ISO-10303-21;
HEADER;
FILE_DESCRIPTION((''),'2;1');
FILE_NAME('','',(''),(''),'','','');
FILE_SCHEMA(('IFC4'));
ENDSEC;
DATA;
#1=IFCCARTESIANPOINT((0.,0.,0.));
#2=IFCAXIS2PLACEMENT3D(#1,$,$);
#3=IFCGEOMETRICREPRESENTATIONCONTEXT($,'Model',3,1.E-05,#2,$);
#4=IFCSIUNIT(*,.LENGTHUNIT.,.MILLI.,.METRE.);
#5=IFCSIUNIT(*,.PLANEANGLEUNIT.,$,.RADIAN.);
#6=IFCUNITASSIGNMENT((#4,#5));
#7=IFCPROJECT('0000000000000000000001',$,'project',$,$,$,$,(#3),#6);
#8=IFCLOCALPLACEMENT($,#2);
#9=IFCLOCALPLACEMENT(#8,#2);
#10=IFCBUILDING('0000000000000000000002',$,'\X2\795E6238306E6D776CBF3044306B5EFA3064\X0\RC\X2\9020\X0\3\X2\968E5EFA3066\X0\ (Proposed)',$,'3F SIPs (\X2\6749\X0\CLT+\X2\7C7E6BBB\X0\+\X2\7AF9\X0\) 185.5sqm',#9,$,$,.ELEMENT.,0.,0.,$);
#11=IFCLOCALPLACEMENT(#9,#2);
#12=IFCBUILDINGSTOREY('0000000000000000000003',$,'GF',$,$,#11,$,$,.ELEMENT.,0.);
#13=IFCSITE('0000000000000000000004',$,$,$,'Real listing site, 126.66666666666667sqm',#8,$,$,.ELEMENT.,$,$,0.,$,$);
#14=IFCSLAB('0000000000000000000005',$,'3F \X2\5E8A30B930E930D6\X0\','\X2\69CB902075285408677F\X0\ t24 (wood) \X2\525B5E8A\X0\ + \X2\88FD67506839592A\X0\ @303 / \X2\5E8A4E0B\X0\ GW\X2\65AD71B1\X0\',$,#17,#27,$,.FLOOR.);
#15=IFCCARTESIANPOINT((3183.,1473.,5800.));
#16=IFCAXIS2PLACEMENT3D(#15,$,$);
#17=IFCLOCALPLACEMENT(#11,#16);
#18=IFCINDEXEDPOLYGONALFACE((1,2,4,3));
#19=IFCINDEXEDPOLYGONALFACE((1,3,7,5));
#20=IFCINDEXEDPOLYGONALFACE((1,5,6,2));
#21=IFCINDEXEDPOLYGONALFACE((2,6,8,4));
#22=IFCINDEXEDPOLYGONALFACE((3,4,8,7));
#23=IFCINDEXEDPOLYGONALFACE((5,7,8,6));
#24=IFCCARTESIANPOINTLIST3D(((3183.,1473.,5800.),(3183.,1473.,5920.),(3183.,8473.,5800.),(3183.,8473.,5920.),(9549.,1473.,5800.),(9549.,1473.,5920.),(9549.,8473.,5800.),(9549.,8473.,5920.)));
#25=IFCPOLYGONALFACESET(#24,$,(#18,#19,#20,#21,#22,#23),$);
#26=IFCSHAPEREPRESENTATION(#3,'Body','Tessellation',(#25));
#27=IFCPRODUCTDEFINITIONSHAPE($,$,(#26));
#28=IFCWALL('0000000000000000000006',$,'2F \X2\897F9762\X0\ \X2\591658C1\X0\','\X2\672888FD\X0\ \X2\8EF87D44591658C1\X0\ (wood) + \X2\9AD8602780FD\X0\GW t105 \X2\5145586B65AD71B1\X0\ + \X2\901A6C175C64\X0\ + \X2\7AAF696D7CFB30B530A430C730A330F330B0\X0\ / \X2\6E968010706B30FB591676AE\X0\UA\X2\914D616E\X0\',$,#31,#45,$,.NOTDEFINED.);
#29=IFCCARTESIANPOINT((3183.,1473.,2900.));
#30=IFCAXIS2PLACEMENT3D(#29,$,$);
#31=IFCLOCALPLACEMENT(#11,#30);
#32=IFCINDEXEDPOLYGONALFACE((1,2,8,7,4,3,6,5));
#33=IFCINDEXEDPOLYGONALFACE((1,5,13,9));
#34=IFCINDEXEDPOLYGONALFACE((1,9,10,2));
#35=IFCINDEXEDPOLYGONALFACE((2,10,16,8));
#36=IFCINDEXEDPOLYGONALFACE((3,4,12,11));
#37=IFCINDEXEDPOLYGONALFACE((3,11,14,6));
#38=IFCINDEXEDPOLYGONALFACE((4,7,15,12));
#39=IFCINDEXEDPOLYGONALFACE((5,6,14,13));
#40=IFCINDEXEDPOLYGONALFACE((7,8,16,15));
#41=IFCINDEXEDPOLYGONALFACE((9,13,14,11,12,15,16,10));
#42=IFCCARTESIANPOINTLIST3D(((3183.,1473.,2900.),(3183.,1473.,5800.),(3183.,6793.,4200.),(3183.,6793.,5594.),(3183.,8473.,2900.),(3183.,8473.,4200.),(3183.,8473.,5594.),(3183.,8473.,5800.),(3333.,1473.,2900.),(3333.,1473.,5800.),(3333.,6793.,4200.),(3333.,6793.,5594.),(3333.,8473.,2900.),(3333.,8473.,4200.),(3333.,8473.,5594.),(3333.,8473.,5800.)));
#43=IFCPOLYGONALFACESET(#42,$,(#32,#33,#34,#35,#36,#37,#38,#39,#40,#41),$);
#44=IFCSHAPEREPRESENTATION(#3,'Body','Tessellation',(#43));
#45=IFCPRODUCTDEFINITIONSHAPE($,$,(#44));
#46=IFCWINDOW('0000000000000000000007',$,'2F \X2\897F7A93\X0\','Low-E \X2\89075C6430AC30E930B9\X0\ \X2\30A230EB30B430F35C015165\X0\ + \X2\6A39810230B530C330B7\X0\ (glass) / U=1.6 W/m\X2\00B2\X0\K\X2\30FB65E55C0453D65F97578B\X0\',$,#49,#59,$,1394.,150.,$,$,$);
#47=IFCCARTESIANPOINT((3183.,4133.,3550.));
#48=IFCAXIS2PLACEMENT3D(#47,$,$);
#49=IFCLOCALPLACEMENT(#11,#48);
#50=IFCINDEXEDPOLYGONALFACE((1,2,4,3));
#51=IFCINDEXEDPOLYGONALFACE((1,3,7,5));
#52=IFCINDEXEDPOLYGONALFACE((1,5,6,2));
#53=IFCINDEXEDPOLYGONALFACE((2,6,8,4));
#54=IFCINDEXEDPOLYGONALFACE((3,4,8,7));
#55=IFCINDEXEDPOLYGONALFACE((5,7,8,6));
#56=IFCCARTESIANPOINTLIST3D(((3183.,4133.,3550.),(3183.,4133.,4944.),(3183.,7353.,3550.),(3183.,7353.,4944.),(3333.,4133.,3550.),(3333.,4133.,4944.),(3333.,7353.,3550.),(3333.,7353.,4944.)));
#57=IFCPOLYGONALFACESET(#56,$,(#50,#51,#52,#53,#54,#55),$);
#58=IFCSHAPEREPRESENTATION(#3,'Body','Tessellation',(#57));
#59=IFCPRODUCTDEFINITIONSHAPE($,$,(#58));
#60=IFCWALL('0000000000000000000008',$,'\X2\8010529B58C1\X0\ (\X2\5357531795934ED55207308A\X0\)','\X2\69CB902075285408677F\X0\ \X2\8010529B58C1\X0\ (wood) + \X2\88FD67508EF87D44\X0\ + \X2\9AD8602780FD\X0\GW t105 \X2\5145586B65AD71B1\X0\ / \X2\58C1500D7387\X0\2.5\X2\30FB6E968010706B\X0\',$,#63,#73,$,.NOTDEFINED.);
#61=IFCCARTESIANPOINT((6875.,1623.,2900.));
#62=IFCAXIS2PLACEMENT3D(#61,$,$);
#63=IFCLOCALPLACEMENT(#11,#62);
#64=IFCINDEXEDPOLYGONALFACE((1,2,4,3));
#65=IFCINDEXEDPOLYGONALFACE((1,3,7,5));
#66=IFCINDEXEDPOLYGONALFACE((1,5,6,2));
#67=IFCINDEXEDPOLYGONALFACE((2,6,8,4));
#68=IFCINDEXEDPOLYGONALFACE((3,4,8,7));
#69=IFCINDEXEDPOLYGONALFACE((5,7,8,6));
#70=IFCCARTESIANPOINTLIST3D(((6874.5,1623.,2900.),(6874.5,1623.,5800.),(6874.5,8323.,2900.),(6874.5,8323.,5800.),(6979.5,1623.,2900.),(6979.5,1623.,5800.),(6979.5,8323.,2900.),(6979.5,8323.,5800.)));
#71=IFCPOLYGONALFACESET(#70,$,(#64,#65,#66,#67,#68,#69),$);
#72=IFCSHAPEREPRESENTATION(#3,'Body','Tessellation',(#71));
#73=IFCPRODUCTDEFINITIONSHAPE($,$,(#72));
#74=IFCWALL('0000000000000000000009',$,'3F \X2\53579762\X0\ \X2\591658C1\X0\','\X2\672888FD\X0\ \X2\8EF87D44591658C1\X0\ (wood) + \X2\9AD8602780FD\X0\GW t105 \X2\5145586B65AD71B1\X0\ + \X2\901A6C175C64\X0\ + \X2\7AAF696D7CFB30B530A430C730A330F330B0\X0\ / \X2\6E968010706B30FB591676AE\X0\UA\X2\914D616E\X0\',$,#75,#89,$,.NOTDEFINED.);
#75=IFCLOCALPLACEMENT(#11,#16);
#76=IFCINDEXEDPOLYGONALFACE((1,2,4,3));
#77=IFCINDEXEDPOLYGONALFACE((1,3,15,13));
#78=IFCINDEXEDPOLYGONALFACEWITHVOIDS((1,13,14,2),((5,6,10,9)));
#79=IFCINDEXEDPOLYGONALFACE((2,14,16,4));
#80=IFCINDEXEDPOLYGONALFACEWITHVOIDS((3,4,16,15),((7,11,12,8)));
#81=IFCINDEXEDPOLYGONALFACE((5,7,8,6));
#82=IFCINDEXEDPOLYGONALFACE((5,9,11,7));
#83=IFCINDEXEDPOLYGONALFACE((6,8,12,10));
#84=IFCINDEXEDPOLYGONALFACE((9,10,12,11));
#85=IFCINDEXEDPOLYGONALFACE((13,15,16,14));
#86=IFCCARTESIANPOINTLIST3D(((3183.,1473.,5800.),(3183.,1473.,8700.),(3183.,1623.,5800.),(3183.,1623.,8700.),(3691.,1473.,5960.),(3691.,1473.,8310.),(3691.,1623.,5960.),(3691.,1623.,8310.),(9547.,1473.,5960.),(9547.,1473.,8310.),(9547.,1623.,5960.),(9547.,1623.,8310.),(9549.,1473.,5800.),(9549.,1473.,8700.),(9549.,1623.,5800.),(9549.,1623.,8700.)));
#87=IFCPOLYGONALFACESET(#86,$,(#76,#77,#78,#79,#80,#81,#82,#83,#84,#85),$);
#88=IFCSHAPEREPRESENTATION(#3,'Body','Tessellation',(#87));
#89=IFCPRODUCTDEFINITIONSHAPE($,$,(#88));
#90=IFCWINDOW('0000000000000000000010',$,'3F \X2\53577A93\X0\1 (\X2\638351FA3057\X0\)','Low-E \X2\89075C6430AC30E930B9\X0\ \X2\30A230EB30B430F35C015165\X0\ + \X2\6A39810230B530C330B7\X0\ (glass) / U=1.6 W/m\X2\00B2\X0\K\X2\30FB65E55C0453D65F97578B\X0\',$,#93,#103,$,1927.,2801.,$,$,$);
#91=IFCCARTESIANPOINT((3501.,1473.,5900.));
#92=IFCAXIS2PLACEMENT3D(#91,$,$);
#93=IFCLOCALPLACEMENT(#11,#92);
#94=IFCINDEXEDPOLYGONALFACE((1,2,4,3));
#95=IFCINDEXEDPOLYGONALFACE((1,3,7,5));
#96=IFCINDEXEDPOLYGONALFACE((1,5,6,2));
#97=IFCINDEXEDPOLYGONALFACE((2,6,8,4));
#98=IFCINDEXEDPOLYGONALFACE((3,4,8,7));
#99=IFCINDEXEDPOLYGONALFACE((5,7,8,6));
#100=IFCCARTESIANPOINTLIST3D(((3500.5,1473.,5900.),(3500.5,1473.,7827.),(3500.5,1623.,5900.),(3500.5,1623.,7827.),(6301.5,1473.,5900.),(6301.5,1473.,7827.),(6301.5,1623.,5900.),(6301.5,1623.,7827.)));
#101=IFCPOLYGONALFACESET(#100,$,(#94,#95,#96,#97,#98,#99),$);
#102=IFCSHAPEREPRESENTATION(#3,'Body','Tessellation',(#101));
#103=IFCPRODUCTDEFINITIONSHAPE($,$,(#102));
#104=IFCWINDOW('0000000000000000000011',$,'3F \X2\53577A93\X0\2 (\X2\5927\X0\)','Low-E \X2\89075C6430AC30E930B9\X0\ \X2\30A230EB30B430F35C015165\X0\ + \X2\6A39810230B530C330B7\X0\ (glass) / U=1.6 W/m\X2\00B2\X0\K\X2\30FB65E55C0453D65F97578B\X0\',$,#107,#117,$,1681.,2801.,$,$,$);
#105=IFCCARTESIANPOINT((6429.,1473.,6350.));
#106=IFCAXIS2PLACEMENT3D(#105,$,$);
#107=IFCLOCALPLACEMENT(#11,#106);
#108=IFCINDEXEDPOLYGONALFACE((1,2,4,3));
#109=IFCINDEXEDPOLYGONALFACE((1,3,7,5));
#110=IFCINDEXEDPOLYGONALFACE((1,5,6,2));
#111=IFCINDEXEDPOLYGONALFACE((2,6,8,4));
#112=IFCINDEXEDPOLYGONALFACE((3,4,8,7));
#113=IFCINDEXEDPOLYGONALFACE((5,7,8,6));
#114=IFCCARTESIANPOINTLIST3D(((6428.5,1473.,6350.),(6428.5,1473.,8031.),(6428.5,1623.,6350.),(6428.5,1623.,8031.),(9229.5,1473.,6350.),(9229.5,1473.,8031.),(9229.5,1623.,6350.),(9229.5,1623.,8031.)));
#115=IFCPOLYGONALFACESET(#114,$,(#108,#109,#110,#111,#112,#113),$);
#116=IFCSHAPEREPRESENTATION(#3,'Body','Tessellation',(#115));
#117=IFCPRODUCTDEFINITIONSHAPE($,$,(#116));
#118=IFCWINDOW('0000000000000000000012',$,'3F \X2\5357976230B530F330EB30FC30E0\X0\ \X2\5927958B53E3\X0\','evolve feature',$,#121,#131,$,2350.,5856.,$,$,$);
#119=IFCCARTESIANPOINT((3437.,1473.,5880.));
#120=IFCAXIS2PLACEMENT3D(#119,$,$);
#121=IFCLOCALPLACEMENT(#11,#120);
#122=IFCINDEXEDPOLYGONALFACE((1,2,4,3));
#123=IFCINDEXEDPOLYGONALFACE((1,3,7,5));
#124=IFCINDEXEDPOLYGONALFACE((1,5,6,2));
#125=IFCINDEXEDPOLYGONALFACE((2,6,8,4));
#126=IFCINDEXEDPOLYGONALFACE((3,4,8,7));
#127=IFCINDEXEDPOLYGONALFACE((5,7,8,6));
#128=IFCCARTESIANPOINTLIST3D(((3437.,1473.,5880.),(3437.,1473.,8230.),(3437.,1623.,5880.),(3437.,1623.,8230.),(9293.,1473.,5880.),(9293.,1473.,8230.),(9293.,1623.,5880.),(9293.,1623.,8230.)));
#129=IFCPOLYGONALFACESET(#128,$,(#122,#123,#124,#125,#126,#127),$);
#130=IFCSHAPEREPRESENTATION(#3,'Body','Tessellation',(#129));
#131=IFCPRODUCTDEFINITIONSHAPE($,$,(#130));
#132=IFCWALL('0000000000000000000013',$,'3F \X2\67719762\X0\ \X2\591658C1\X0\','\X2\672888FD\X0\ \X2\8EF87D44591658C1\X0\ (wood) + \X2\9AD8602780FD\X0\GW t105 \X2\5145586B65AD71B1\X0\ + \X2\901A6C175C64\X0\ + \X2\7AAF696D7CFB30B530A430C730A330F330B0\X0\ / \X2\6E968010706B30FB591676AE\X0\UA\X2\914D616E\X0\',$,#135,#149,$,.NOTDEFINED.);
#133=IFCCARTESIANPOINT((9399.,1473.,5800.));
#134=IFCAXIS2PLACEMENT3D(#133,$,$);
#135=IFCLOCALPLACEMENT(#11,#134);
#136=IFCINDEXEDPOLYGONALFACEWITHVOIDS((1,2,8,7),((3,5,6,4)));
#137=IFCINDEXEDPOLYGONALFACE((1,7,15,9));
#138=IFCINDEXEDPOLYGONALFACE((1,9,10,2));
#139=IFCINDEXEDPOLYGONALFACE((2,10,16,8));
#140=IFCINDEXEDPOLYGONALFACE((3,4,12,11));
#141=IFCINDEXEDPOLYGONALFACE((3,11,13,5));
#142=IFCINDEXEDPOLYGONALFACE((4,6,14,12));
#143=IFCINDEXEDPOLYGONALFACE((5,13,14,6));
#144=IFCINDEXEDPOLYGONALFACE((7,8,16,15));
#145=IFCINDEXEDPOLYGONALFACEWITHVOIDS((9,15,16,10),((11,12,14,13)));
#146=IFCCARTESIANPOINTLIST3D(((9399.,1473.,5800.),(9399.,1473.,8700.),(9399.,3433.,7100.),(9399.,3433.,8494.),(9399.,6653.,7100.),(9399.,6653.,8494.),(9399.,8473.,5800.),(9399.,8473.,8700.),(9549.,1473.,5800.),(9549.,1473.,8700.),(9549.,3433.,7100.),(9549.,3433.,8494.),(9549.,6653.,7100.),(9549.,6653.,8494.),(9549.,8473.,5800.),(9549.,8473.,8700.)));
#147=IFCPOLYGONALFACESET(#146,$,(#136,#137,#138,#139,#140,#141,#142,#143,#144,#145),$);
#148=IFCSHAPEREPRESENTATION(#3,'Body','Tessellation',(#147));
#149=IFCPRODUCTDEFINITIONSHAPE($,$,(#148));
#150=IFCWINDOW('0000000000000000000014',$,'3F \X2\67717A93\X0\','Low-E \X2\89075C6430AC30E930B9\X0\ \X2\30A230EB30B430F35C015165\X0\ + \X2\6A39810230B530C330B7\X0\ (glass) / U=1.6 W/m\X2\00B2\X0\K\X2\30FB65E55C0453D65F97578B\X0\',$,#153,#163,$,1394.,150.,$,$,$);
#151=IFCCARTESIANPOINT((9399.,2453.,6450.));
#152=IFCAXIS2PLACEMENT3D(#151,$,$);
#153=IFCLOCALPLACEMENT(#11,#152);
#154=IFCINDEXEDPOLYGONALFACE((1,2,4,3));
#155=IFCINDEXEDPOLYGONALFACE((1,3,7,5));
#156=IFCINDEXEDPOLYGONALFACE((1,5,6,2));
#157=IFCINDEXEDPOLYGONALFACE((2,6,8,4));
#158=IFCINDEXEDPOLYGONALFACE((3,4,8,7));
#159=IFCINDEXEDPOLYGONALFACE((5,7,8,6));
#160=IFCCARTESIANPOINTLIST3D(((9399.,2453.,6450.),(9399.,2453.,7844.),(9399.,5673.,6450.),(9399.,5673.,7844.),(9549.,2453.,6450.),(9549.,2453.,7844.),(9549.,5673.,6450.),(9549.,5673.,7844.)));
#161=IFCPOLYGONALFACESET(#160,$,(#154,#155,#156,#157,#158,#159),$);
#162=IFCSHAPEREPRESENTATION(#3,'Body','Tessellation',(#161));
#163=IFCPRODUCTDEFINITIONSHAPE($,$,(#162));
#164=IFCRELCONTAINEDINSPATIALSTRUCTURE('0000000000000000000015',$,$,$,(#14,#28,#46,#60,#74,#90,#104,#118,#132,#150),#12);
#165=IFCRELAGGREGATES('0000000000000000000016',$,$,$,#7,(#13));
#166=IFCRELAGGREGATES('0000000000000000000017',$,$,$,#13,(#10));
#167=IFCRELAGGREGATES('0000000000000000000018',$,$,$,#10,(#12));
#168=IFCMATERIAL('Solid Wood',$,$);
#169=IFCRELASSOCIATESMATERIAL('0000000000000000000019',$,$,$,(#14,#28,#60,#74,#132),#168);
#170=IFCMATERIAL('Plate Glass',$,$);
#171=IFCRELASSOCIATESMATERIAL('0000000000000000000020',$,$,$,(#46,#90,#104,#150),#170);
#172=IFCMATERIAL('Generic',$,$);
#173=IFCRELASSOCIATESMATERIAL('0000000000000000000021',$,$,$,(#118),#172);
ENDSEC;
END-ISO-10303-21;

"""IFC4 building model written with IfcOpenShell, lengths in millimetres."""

from ifc_helpers import new_model, si_unit, frame, frame_2d, origin, place, context, project, spatial, rectangle, extrude, material, element, fill, save


model = new_model("IFC4")

# Units and contexts
model_context = context("Model", 3, precision=1e-05, world=origin())
ifc_project = project(units=[si_unit("LENGTHUNIT", "METRE", prefix="MILLI"), si_unit("PLANEANGLEUNIT", "RADIAN")], contexts=[model_context])

# Site, building, storey
site_placement = place(None, origin())
site = spatial("IfcSite", under=ifc_project, at=site_placement, ObjectType="Real listing site, 126.66666666666667sqm", CompositionType="ELEMENT", RefElevation=0.0)
building_placement = place(site_placement, origin())
building = spatial("IfcBuilding", under=site, at=building_placement, Name="神戸の海沿いに建つRC造3階建て (Proposed)", ObjectType="3F SIPs (杉CLT+籾殻+竹) 185.5sqm", CompositionType="ELEMENT", ElevationOfRefHeight=0.0, ElevationOfTerrain=0.0)
storey_placement = place(building_placement, origin())
storey = spatial("IfcBuildingStorey", under=building, at=storey_placement, Name="GF", CompositionType="ELEMENT", Elevation=0.0)

# Slab
ifc_material_1 = material(Name="Solid Wood")
slab_placement = place(storey_placement, frame((3183.0, 1473.0, 5800.0)))
element("IfcSlab", 1, at=slab_placement, inside=storey, material=ifc_material_1, Name="3F 床スラブ", Description="構造用合板 t24 (wood) 剛床 + 製材根太 @303 / 床下 GW断熱", PredefinedType="FLOOR", context=model_context, shape_type="SweptSolid", body=[
    extrude(rectangle(XDim=6366.0, YDim=7000.0, at=frame_2d((3183.0, 3500.0))), frame((3183.0, 1473.0, 5800.0)), (0.0, 0.0, 1.0), 120.0),
])

# Wall, opening, window
wall_1_placement = place(storey_placement, frame((3183.0, 1473.0, 2900.0)))
wall_1 = element("IfcWall", 2, at=wall_1_placement, inside=storey, material=ifc_material_1, Name="2F 西面 外壁", Description="木製 軸組外壁 (wood) + 高性能GW t105 充填断熱 + 通気層 + 窯業系サイディング / 準耐火・外皮UA配慮", PredefinedType="NOTDEFINED", context=model_context, shape_type="SweptSolid", body=[
    extrude(rectangle(XDim=150.0, YDim=7000.0, at=frame_2d((75.0, 3500.0))), frame((3183.0, 1473.0, 2900.0)), (0.0, 0.0, 1.0), 2900.0),
])
opening_1_placement = place(storey_placement, frame((3183.0, 4133.0, 3550.0)))
opening_1 = element("IfcOpeningElement", 3, at=opening_1_placement, cuts=wall_1, PredefinedType="NOTDEFINED", context=model_context, shape_type="SweptSolid", body=[
    extrude(rectangle(XDim=150.0, YDim=3220.0, at=frame_2d((75.0, 1610.0))), frame((3183.0, 4133.0, 3550.0)), (0.0, 0.0, 1.0), 1394.0),
])
ifc_material_2 = material(Name="Plate Glass")
window_1_placement = place(storey_placement, frame((3183.0, 4133.0, 3550.0)))
window_1 = element("IfcWindow", 4, at=window_1_placement, inside=storey, material=ifc_material_2, Name="2F 西窓", Description="Low-E 複層ガラス アルゴン封入 + 樹脂サッシ (glass) / U=1.6 W/m²K・日射取得型", OverallHeight=1394.0, OverallWidth=150.0, context=model_context, shape_type="SweptSolid", body=[
    extrude(rectangle(XDim=150.0, YDim=3220.0, at=frame_2d((75.0, 1610.0))), frame((3183.0, 4133.0, 3550.0)), (0.0, 0.0, 1.0), 1394.0),
])
fill(opening_1, window_1)

# Wall
wall_2_placement = place(storey_placement, frame((6875.0, 1623.0, 2900.0)))
element("IfcWall", 5, at=wall_2_placement, inside=storey, material=ifc_material_1, Name="耐力壁 (南北間仕切り)", Description="構造用合板 耐力壁 (wood) + 製材軸組 + 高性能GW t105 充填断熱 / 壁倍率2.5・準耐火", PredefinedType="NOTDEFINED", context=model_context, shape_type="SweptSolid", body=[
    extrude(rectangle(XDim=105.0, YDim=6700.0, at=frame_2d((52.0, 3350.0))), frame((6875.0, 1623.0, 2900.0)), (0.0, 0.0, 1.0), 2900.0),
])

# Wall, openings, windows
wall_3_placement = place(storey_placement, frame((3183.0, 1473.0, 5800.0)))
wall_3 = element("IfcWall", 6, at=wall_3_placement, inside=storey, material=ifc_material_1, Name="3F 南面 外壁", Description="木製 軸組外壁 (wood) + 高性能GW t105 充填断熱 + 通気層 + 窯業系サイディング / 準耐火・外皮UA配慮", PredefinedType="NOTDEFINED", context=model_context, shape_type="SweptSolid", body=[
    extrude(rectangle(XDim=6366.0, YDim=150.0, at=frame_2d((3183.0, 75.0))), frame((3183.0, 1473.0, 5800.0)), (0.0, 0.0, 1.0), 2900.0),
])
opening_2_placement = place(storey_placement, frame((3501.0, 1473.0, 5900.0)))
opening_2 = element("IfcOpeningElement", 7, at=opening_2_placement, cuts=wall_3, PredefinedType="NOTDEFINED", context=model_context, shape_type="SweptSolid", body=[
    extrude(rectangle(XDim=2801.0, YDim=150.0, at=frame_2d((1400.0, 75.0))), frame((3501.0, 1473.0, 5900.0)), (0.0, 0.0, 1.0), 1927.0),
])
opening_3_placement = place(storey_placement, frame((6429.0, 1473.0, 6350.0)))
opening_3 = element("IfcOpeningElement", 8, at=opening_3_placement, cuts=wall_3, PredefinedType="NOTDEFINED", context=model_context, shape_type="SweptSolid", body=[
    extrude(rectangle(XDim=2801.0, YDim=150.0, at=frame_2d((1400.0, 75.0))), frame((6429.0, 1473.0, 6350.0)), (0.0, 0.0, 1.0), 1681.0),
])
opening_4_placement = place(storey_placement, frame((3437.0, 1473.0, 5880.0)))
opening_4 = element("IfcOpeningElement", 9, at=opening_4_placement, cuts=wall_3, PredefinedType="NOTDEFINED", context=model_context, shape_type="SweptSolid", body=[
    extrude(rectangle(XDim=5856.0, YDim=150.0, at=frame_2d((2928.0, 75.0))), frame((3437.0, 1473.0, 5880.0)), (0.0, 0.0, 1.0), 2350.0),
])
window_2_placement = place(storey_placement, frame((3501.0, 1473.0, 5900.0)))
window_2 = element("IfcWindow", 10, at=window_2_placement, inside=storey, material=ifc_material_2, Name="3F 南窓1 (掃出し)", Description="Low-E 複層ガラス アルゴン封入 + 樹脂サッシ (glass) / U=1.6 W/m²K・日射取得型", OverallHeight=1927.0, OverallWidth=2801.0, context=model_context, shape_type="SweptSolid", body=[
    extrude(rectangle(XDim=2801.0, YDim=150.0, at=frame_2d((1400.0, 75.0))), frame((3501.0, 1473.0, 5900.0)), (0.0, 0.0, 1.0), 1927.0),
])
fill(opening_2, window_2)
window_3_placement = place(storey_placement, frame((6429.0, 1473.0, 6350.0)))
window_3 = element("IfcWindow", 11, at=window_3_placement, inside=storey, material=ifc_material_2, Name="3F 南窓2 (大)", Description="Low-E 複層ガラス アルゴン封入 + 樹脂サッシ (glass) / U=1.6 W/m²K・日射取得型", OverallHeight=1681.0, OverallWidth=2801.0, context=model_context, shape_type="SweptSolid", body=[
    extrude(rectangle(XDim=2801.0, YDim=150.0, at=frame_2d((1400.0, 75.0))), frame((6429.0, 1473.0, 6350.0)), (0.0, 0.0, 1.0), 1681.0),
])
fill(opening_3, window_3)
ifc_material_3 = material(Name="Generic")
window_4_placement = place(storey_placement, frame((3437.0, 1473.0, 5880.0)))
window_4 = element("IfcWindow", 12, at=window_4_placement, inside=storey, material=ifc_material_3, Name="3F 南面サンルーム 大開口", Description="evolve feature", OverallHeight=2350.0, OverallWidth=5856.0, context=model_context, shape_type="SweptSolid", body=[
    extrude(rectangle(XDim=5856.0, YDim=150.0, at=frame_2d((2928.0, 75.0))), frame((3437.0, 1473.0, 5880.0)), (0.0, 0.0, 1.0), 2350.0),
])
fill(opening_4, window_4)

# Wall, opening, window
wall_4_placement = place(storey_placement, frame((9399.0, 1473.0, 5800.0)))
wall_4 = element("IfcWall", 13, at=wall_4_placement, inside=storey, material=ifc_material_1, Name="3F 東面 外壁", Description="木製 軸組外壁 (wood) + 高性能GW t105 充填断熱 + 通気層 + 窯業系サイディング / 準耐火・外皮UA配慮", PredefinedType="NOTDEFINED", context=model_context, shape_type="SweptSolid", body=[
    extrude(rectangle(XDim=150.0, YDim=7000.0, at=frame_2d((75.0, 3500.0))), frame((9399.0, 1473.0, 5800.0)), (0.0, 0.0, 1.0), 2900.0),
])
opening_5_placement = place(storey_placement, frame((9399.0, 2453.0, 6450.0)))
opening_5 = element("IfcOpeningElement", 14, at=opening_5_placement, cuts=wall_4, PredefinedType="NOTDEFINED", context=model_context, shape_type="SweptSolid", body=[
    extrude(rectangle(XDim=150.0, YDim=3220.0, at=frame_2d((75.0, 1610.0))), frame((9399.0, 2453.0, 6450.0)), (0.0, 0.0, 1.0), 1394.0),
])
window_5_placement = place(storey_placement, frame((9399.0, 2453.0, 6450.0)))
window_5 = element("IfcWindow", 15, at=window_5_placement, inside=storey, material=ifc_material_2, Name="3F 東窓", Description="Low-E 複層ガラス アルゴン封入 + 樹脂サッシ (glass) / U=1.6 W/m²K・日射取得型", OverallHeight=1394.0, OverallWidth=150.0, context=model_context, shape_type="SweptSolid", body=[
    extrude(rectangle(XDim=150.0, YDim=3220.0, at=frame_2d((75.0, 1610.0))), frame((9399.0, 2453.0, 6450.0)), (0.0, 0.0, 1.0), 1394.0),
])
fill(opening_5, window_5)

save(model, "model.ifc")
